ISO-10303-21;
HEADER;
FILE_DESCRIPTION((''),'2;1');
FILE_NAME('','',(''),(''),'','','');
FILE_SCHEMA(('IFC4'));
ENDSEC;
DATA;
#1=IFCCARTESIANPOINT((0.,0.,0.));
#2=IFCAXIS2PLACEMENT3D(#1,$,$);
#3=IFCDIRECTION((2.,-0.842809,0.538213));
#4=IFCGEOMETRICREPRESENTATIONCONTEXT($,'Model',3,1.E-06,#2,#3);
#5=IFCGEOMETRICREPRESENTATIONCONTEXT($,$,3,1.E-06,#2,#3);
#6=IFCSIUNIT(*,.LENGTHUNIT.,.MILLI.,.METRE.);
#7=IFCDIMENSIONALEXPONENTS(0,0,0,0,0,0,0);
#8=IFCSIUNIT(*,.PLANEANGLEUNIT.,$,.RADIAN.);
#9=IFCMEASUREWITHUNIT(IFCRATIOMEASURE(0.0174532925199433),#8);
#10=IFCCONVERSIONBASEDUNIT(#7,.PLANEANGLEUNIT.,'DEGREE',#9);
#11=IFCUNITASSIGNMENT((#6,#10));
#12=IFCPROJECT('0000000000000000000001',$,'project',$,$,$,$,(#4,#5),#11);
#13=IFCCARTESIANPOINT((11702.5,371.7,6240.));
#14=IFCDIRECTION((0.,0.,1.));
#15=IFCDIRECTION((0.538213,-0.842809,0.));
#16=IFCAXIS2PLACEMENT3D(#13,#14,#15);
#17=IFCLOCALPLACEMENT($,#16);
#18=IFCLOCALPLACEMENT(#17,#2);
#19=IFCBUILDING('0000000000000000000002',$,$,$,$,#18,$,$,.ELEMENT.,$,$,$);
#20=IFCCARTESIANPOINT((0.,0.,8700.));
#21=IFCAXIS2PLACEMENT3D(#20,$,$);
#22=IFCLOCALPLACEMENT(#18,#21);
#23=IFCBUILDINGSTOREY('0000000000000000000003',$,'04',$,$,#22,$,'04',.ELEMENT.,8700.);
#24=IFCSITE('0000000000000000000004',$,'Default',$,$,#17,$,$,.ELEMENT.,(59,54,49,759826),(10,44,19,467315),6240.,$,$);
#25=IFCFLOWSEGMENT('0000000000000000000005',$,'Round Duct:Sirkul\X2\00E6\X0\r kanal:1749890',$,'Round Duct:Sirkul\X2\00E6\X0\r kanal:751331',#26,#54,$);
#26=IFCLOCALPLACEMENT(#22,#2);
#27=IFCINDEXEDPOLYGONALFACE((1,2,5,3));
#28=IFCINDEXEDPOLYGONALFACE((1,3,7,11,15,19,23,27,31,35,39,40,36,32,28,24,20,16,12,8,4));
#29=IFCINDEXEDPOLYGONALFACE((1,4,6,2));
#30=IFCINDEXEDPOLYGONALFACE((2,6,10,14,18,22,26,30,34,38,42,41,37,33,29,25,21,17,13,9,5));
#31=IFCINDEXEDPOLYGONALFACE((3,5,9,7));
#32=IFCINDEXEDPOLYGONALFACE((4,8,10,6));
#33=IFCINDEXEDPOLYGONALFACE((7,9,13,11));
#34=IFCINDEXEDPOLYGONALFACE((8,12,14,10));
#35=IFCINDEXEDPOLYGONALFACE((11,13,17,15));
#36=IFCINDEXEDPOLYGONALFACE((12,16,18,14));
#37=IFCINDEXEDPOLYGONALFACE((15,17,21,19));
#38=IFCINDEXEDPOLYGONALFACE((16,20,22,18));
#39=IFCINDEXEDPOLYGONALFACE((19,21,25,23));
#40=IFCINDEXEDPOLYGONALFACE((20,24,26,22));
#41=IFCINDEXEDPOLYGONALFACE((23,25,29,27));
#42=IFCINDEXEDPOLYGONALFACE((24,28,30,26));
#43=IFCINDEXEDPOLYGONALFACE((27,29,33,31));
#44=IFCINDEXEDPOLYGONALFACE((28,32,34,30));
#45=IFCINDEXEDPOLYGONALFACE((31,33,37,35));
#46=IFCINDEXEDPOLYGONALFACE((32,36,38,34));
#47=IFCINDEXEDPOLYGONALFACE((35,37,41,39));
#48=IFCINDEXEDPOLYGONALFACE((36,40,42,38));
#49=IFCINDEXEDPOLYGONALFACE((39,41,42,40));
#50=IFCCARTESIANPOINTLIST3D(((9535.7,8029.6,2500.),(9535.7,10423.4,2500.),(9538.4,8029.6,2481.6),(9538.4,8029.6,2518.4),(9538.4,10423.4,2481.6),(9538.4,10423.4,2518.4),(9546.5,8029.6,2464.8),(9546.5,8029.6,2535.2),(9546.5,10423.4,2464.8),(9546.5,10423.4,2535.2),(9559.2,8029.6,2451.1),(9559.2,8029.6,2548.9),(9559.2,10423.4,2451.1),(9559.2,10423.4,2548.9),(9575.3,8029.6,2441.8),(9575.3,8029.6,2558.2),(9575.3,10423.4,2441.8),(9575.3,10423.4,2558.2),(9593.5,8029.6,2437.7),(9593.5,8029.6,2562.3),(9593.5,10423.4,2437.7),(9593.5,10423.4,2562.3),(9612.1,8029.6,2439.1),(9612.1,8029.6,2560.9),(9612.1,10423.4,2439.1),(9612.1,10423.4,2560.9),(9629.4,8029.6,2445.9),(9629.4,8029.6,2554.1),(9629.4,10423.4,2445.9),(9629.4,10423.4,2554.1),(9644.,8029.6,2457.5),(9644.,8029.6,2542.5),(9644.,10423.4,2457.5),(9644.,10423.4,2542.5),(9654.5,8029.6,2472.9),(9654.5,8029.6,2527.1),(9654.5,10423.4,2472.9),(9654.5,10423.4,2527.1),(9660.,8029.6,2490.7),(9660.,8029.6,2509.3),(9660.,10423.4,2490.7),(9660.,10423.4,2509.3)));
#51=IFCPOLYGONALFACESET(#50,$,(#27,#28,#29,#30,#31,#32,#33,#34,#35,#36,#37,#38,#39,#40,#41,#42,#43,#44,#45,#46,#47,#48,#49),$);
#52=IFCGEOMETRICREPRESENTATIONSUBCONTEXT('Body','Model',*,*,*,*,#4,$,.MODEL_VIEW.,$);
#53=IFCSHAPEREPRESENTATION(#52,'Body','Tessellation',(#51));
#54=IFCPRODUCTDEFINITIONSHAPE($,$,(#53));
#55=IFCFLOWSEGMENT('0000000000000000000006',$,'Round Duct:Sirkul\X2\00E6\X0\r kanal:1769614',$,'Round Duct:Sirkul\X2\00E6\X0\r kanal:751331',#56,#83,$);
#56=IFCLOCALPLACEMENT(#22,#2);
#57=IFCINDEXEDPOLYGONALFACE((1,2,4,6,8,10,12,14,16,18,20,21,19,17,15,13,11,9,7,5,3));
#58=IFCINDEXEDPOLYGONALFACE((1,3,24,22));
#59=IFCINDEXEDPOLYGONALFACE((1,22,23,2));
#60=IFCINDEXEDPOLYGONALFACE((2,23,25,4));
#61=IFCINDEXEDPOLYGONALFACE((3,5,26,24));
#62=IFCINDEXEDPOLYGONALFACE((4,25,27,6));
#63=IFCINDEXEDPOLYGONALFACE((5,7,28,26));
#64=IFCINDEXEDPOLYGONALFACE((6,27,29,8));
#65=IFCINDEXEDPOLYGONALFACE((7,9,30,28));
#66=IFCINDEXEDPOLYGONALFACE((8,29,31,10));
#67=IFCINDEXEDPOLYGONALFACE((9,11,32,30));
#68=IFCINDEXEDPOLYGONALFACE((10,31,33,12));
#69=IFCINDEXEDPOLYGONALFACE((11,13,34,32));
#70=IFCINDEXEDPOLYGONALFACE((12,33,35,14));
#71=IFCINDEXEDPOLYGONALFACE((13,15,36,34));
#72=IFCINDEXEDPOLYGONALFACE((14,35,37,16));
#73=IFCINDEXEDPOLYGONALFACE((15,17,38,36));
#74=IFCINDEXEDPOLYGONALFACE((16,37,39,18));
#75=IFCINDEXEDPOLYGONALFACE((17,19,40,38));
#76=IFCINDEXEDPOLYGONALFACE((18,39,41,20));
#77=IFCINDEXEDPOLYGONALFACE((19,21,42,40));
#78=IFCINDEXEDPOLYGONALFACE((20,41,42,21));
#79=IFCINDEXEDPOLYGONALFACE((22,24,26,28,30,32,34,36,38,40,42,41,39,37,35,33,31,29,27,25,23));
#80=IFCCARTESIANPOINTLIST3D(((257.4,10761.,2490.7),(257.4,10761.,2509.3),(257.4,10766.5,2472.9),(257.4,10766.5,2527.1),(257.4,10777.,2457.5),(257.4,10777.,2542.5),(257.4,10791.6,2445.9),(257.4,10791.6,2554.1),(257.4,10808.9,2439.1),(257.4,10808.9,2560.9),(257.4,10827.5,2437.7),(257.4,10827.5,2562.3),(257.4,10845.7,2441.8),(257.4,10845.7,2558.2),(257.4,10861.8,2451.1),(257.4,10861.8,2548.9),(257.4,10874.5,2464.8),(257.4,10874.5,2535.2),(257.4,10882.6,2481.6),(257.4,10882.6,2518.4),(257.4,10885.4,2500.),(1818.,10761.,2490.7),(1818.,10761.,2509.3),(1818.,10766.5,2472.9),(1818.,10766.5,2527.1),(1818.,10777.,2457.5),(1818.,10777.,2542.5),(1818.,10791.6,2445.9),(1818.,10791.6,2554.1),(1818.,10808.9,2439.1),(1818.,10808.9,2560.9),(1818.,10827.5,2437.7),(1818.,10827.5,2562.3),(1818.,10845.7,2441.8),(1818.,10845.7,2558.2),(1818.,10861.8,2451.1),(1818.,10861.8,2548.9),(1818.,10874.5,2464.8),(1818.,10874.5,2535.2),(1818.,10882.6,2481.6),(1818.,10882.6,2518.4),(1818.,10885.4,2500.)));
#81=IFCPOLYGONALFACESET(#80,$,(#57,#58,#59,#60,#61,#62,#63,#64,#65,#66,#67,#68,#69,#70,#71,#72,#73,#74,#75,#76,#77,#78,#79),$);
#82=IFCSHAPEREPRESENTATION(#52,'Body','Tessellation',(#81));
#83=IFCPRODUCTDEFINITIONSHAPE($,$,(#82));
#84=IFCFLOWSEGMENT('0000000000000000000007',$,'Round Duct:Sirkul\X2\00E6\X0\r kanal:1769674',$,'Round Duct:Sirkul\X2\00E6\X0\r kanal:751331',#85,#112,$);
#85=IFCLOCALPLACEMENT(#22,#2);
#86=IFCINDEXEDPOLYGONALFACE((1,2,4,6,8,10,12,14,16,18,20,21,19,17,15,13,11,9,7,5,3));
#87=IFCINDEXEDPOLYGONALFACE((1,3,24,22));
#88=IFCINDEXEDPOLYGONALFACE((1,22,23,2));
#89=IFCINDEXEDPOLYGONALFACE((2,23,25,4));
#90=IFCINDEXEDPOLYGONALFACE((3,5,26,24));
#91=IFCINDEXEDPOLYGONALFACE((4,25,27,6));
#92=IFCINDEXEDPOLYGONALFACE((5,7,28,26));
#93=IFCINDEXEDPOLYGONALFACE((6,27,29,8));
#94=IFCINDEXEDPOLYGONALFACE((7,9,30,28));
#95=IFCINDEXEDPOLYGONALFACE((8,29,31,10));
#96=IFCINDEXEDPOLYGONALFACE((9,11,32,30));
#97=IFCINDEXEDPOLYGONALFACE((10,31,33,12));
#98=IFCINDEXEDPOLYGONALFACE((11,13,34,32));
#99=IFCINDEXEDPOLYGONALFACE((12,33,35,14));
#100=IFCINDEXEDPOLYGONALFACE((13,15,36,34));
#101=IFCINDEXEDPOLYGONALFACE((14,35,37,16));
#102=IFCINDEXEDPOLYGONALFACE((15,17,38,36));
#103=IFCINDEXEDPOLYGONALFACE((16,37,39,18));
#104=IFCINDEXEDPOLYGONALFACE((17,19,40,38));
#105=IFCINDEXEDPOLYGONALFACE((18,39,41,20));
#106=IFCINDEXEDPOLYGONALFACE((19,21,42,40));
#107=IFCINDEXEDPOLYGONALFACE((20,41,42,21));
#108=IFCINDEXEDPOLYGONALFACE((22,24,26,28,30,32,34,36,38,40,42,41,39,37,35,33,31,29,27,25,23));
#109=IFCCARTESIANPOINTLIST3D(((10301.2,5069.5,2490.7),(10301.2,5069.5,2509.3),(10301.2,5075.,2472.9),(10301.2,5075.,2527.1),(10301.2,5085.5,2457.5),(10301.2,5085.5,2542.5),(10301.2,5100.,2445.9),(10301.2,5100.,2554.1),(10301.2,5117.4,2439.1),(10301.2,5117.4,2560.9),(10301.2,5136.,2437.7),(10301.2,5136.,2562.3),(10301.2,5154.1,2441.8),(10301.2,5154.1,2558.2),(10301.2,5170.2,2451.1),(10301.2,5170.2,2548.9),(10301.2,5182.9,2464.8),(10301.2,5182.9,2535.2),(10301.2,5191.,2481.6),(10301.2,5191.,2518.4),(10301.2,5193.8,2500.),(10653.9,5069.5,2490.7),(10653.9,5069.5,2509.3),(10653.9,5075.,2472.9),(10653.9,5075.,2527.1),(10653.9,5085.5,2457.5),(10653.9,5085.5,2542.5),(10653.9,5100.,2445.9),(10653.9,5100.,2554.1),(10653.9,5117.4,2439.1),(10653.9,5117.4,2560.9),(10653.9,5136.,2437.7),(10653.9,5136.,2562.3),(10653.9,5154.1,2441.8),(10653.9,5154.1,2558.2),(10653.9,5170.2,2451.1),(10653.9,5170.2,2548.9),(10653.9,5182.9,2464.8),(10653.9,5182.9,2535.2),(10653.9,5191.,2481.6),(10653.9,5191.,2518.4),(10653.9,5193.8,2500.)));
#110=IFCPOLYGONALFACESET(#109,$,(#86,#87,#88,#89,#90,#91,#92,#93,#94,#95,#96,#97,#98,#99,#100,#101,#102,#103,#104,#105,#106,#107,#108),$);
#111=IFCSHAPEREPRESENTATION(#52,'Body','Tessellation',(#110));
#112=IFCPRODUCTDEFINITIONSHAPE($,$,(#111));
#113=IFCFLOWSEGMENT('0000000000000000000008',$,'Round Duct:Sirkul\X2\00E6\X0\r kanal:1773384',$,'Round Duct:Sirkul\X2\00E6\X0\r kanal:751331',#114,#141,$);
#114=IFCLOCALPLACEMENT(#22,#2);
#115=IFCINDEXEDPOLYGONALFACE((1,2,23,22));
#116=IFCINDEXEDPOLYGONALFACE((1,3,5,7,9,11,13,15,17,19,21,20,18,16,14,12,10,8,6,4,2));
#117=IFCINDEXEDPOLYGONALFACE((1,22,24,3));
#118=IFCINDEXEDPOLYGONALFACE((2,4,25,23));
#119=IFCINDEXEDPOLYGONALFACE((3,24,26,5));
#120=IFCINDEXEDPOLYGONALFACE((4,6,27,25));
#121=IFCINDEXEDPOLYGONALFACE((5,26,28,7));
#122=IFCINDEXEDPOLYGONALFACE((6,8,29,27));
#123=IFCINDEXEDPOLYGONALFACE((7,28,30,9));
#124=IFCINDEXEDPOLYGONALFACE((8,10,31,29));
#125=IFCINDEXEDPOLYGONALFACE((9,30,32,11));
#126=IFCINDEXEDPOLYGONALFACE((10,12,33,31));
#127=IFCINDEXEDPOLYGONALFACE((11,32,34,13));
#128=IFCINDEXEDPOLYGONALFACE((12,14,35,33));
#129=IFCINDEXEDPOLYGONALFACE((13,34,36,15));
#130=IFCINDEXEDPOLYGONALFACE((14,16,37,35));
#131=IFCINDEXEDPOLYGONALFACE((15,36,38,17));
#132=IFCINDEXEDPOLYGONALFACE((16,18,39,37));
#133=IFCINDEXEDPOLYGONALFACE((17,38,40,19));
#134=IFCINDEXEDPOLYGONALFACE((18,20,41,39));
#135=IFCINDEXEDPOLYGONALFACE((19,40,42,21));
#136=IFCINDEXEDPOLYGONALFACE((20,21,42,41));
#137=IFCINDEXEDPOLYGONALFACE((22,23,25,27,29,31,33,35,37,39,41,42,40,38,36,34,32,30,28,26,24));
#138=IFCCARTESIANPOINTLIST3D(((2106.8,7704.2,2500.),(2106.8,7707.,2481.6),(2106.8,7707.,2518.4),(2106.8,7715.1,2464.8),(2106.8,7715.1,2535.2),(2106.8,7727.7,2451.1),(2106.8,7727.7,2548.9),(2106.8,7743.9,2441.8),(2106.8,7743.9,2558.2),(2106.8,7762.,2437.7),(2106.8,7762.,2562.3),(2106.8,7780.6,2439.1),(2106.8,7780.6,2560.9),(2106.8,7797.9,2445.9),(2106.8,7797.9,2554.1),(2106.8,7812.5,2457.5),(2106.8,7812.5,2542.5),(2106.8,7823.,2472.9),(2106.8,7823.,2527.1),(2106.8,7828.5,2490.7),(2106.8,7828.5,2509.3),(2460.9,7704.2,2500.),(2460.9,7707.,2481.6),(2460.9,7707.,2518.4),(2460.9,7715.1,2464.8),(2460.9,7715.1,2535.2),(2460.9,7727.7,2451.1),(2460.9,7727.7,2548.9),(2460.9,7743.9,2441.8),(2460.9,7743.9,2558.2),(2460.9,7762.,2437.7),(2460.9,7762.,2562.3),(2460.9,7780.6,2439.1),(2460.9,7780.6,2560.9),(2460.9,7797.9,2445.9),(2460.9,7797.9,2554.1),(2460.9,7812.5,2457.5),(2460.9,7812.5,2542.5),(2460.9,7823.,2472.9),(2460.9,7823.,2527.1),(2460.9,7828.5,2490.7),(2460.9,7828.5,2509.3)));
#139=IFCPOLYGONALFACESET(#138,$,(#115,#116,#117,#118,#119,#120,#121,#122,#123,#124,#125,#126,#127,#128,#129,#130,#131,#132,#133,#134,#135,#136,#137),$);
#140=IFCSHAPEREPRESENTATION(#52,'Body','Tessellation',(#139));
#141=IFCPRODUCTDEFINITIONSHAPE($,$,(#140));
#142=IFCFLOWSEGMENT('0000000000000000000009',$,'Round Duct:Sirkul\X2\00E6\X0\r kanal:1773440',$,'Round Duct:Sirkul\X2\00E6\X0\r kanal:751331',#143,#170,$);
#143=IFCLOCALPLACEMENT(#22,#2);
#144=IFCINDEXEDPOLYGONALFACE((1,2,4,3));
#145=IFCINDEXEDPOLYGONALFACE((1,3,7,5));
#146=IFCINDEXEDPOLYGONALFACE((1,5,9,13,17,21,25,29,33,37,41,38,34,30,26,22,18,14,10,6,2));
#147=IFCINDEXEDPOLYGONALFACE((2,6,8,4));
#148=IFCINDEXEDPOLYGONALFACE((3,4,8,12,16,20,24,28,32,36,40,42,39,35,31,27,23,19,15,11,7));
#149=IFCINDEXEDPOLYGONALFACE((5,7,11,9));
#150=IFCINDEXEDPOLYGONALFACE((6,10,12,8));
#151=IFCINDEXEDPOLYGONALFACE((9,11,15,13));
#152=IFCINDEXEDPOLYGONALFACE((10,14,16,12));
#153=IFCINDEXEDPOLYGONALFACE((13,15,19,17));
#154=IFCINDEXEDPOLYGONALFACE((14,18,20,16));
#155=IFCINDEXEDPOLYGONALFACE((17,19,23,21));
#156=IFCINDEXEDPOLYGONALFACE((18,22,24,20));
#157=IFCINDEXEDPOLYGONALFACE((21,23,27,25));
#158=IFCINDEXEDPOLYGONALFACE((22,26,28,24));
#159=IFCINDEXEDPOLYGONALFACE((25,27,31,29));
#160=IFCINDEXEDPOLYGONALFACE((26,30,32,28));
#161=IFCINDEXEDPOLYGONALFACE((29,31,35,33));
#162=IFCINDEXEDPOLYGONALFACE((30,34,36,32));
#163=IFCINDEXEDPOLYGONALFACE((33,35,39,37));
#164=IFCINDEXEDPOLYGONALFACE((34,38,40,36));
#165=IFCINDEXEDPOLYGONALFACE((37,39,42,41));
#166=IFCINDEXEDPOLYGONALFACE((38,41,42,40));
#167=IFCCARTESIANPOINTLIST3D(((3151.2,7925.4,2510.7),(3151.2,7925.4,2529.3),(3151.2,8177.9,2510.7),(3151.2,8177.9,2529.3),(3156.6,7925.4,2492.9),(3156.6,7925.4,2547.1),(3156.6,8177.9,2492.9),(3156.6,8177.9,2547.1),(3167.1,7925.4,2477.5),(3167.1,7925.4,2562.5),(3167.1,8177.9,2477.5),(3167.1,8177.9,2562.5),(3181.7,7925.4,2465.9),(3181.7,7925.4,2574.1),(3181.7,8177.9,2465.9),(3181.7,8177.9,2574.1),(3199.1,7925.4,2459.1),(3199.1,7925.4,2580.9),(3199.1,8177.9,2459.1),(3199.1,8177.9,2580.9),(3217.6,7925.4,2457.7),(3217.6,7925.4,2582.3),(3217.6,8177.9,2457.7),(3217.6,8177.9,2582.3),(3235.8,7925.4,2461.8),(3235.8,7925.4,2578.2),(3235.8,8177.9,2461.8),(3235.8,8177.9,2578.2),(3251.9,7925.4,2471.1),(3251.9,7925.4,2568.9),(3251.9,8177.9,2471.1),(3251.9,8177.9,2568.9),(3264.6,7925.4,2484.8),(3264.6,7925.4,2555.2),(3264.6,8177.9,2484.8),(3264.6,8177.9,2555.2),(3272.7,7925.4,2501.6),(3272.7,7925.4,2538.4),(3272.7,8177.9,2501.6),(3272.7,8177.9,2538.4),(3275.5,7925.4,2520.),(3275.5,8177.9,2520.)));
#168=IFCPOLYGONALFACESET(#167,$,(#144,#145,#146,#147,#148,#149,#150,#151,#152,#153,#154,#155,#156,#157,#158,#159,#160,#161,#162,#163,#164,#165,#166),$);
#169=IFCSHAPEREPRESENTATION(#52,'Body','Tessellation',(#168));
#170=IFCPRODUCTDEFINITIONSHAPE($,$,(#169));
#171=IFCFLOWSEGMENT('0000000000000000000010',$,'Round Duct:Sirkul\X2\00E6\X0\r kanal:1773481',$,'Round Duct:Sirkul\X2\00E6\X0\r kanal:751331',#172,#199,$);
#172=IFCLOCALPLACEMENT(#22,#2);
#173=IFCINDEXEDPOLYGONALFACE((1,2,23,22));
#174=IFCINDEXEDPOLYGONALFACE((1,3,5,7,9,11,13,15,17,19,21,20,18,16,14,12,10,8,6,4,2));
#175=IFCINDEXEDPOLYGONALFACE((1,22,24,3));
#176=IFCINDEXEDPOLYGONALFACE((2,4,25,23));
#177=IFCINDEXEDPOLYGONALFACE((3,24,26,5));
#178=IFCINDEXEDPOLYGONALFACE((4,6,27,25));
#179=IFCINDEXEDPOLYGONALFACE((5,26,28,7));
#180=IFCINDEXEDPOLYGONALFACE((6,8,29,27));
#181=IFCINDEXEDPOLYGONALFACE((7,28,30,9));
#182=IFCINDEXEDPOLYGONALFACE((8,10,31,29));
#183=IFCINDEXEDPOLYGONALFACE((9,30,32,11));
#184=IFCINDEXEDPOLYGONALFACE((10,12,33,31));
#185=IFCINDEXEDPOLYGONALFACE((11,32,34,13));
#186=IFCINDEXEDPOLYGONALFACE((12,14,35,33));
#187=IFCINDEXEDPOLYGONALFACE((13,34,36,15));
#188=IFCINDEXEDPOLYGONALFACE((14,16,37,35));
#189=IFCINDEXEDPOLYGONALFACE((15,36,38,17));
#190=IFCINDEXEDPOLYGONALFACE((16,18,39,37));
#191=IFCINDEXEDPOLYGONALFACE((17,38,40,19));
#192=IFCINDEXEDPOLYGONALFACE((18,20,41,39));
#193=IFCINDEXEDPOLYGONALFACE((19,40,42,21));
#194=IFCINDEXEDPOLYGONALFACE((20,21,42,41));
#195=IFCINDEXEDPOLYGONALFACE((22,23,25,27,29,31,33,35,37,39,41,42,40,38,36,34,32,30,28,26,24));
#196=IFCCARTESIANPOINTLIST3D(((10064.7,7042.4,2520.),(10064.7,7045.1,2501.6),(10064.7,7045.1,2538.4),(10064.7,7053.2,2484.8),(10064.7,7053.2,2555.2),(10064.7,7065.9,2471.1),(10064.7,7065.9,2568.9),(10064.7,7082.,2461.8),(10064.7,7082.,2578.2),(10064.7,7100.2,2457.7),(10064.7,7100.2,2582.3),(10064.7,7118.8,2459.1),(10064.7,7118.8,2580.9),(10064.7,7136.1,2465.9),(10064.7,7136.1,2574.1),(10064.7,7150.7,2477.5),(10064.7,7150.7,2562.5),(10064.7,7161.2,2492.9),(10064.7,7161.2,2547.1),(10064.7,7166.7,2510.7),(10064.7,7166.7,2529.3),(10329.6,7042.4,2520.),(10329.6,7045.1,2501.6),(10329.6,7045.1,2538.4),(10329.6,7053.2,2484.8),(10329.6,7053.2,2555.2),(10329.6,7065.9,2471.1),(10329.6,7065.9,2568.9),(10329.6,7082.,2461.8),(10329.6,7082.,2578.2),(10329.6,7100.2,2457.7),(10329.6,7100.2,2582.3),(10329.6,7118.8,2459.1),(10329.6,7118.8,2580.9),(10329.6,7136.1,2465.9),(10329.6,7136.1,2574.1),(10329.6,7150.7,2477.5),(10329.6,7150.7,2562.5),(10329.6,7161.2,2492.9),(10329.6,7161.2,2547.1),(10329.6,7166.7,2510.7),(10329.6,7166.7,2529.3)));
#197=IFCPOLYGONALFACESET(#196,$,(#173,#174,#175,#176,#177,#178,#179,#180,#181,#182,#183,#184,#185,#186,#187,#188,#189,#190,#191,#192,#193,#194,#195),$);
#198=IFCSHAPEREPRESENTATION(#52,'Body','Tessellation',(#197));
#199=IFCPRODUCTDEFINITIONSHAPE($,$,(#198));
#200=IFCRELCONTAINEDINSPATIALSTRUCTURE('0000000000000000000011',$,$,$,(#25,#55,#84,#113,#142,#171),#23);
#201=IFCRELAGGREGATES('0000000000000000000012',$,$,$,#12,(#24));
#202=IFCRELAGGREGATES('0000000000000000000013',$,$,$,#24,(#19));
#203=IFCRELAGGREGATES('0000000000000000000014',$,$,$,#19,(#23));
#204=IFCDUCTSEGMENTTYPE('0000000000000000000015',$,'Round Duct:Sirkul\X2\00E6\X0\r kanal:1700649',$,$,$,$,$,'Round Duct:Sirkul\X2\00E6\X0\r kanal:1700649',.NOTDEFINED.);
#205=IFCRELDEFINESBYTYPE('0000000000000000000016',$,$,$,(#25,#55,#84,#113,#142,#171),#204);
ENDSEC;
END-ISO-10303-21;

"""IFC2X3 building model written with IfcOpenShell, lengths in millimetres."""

from ifc_helpers import new_model, entity, si_unit, converted_unit, direction, frame, frame_2d, origin, origin_2d_with_axis, place, context, subcontext, project, spatial, circle, extrude, type_object, element, save


model = new_model("IFC2X3")

# Units and contexts
model_context = context("Model", 3, precision=1e-06, world=origin(), true_north=direction((2.0, -0.842809, 0.538213)))
context_of_model = context(None, 3, precision=1e-06, world=origin(), true_north=direction((2.0, -0.842809, 0.538213)))
body_context = subcontext(model_context, "Body", "Model", "MODEL_VIEW")
ifc_project = project(units=[si_unit("LENGTHUNIT", "METRE", prefix="MILLI"), converted_unit("PLANEANGLEUNIT", "DEGREE", entity("IfcRatioMeasure", 0.0174532925199433), si_unit("PLANEANGLEUNIT", "RADIAN"), dimensions=[0, 0, 0, 0, 0, 0, 0])], contexts=[model_context, context_of_model])

# Site, building, storey
site_placement = place(None, frame((11702.5, 371.7, 6240.0), z_axis=(0.0, 0.0, 1.0), x_axis=(0.538213, -0.842809, 0.0)))
site = spatial("IfcSite", under=ifc_project, at=site_placement, Name="Default", CompositionType="ELEMENT", RefLatitude=(59, 54, 49, 759826), RefLongitude=(10, 44, 19, 467315), RefElevation=6240.0)
building_placement = place(site_placement, origin())
building = spatial("IfcBuilding", under=site, at=building_placement, CompositionType="ELEMENT")
storey_placement = place(building_placement, frame((0.0, 0.0, 8700.0)))
storey = spatial("IfcBuildingStorey", under=building, at=storey_placement, Name="04", LongName="04", CompositionType="ELEMENT", Elevation=8700.0)

# Flow segments
duct_segment_type = type_object("IfcDuctSegmentType", Name="Round Duct:Sirkulær kanal:1700649", ElementType="Round Duct:Sirkulær kanal:1700649", PredefinedType="NOTDEFINED")
flow_segment_1_placement = place(storey_placement, origin())
element("IfcFlowSegment", 1, at=flow_segment_1_placement, inside=storey, type_object=duct_segment_type, Name="Round Duct:Sirkulær kanal:1749890", ObjectType="Round Duct:Sirkulær kanal:751331", context=body_context, shape_type="SweptSolid", body=[
    extrude(circle(Radius=62.5, at=frame_2d((0.0, 0.0), x_axis=(1.0, 0.0))), frame((9598.2, 8029.6, 2500.0), z_axis=(0.0, 1.0, 0.0), x_axis=(-1.0, 0.0, 0.0)), (0.0, 0.0, 1.0), 2393.8),
])
flow_segment_2_placement = place(storey_placement, origin())
element("IfcFlowSegment", 2, at=flow_segment_2_placement, inside=storey, type_object=duct_segment_type, Name="Round Duct:Sirkulær kanal:1769614", ObjectType="Round Duct:Sirkulær kanal:751331", context=body_context, shape_type="SweptSolid", body=[
    extrude(circle(Radius=62.5, at=origin_2d_with_axis()), frame((257.4, 10822.9, 2500.0), z_axis=(1.0, 0.0, 0.0), x_axis=(0.0, 1.0, 0.0)), (0.0, 0.0, 1.0), 1560.5),
])
flow_segment_3_placement = place(storey_placement, origin())
element("IfcFlowSegment", 3, at=flow_segment_3_placement, inside=storey, type_object=duct_segment_type, Name="Round Duct:Sirkulær kanal:1769674", ObjectType="Round Duct:Sirkulær kanal:751331", context=body_context, shape_type="SweptSolid", body=[
    extrude(circle(Radius=62.5, at=origin_2d_with_axis()), frame((10301.2, 5131.3, 2500.0), z_axis=(1.0, 0.0, 0.0), x_axis=(0.0, 1.0, 0.0)), (0.0, 0.0, 1.0), 352.7),
])
flow_segment_4_placement = place(storey_placement, origin())
element("IfcFlowSegment", 4, at=flow_segment_4_placement, inside=storey, type_object=duct_segment_type, Name="Round Duct:Sirkulær kanal:1773384", ObjectType="Round Duct:Sirkulær kanal:751331", context=body_context, shape_type="SweptSolid", body=[
    extrude(circle(Radius=62.5, at=frame_2d((0.0, 0.0), x_axis=(1.0, 0.0))), frame((2106.8, 7766.7, 2500.0), z_axis=(1.0, 0.0, 0.0), x_axis=(0.0, -1.0, 0.0)), (0.0, 0.0, 1.0), 354.1),
])
flow_segment_5_placement = place(storey_placement, origin())
element("IfcFlowSegment", 5, at=flow_segment_5_placement, inside=storey, type_object=duct_segment_type, Name="Round Duct:Sirkulær kanal:1773440", ObjectType="Round Duct:Sirkulær kanal:751331", context=body_context, shape_type="SweptSolid", body=[
    extrude(circle(Radius=62.5, at=frame_2d((0.0, 0.0), x_axis=(1.0, 0.0))), frame((3213.0, 7925.4, 2520.0), z_axis=(0.0, 1.0, 0.0), x_axis=(1.0, 0.0, 0.0)), (0.0, 0.0, 1.0), 252.6),
])
flow_segment_6_placement = place(storey_placement, origin())
element("IfcFlowSegment", 6, at=flow_segment_6_placement, inside=storey, type_object=duct_segment_type, Name="Round Duct:Sirkulær kanal:1773481", ObjectType="Round Duct:Sirkulær kanal:751331", context=body_context, shape_type="SweptSolid", body=[
    extrude(circle(Radius=62.5, at=origin_2d_with_axis()), frame((10064.7, 7104.9, 2520.0), z_axis=(1.0, 0.0, 0.0), x_axis=(0.0, -1.0, 0.0)), (0.0, 0.0, 1.0), 264.9),
])

save(model, "model.ifc")
